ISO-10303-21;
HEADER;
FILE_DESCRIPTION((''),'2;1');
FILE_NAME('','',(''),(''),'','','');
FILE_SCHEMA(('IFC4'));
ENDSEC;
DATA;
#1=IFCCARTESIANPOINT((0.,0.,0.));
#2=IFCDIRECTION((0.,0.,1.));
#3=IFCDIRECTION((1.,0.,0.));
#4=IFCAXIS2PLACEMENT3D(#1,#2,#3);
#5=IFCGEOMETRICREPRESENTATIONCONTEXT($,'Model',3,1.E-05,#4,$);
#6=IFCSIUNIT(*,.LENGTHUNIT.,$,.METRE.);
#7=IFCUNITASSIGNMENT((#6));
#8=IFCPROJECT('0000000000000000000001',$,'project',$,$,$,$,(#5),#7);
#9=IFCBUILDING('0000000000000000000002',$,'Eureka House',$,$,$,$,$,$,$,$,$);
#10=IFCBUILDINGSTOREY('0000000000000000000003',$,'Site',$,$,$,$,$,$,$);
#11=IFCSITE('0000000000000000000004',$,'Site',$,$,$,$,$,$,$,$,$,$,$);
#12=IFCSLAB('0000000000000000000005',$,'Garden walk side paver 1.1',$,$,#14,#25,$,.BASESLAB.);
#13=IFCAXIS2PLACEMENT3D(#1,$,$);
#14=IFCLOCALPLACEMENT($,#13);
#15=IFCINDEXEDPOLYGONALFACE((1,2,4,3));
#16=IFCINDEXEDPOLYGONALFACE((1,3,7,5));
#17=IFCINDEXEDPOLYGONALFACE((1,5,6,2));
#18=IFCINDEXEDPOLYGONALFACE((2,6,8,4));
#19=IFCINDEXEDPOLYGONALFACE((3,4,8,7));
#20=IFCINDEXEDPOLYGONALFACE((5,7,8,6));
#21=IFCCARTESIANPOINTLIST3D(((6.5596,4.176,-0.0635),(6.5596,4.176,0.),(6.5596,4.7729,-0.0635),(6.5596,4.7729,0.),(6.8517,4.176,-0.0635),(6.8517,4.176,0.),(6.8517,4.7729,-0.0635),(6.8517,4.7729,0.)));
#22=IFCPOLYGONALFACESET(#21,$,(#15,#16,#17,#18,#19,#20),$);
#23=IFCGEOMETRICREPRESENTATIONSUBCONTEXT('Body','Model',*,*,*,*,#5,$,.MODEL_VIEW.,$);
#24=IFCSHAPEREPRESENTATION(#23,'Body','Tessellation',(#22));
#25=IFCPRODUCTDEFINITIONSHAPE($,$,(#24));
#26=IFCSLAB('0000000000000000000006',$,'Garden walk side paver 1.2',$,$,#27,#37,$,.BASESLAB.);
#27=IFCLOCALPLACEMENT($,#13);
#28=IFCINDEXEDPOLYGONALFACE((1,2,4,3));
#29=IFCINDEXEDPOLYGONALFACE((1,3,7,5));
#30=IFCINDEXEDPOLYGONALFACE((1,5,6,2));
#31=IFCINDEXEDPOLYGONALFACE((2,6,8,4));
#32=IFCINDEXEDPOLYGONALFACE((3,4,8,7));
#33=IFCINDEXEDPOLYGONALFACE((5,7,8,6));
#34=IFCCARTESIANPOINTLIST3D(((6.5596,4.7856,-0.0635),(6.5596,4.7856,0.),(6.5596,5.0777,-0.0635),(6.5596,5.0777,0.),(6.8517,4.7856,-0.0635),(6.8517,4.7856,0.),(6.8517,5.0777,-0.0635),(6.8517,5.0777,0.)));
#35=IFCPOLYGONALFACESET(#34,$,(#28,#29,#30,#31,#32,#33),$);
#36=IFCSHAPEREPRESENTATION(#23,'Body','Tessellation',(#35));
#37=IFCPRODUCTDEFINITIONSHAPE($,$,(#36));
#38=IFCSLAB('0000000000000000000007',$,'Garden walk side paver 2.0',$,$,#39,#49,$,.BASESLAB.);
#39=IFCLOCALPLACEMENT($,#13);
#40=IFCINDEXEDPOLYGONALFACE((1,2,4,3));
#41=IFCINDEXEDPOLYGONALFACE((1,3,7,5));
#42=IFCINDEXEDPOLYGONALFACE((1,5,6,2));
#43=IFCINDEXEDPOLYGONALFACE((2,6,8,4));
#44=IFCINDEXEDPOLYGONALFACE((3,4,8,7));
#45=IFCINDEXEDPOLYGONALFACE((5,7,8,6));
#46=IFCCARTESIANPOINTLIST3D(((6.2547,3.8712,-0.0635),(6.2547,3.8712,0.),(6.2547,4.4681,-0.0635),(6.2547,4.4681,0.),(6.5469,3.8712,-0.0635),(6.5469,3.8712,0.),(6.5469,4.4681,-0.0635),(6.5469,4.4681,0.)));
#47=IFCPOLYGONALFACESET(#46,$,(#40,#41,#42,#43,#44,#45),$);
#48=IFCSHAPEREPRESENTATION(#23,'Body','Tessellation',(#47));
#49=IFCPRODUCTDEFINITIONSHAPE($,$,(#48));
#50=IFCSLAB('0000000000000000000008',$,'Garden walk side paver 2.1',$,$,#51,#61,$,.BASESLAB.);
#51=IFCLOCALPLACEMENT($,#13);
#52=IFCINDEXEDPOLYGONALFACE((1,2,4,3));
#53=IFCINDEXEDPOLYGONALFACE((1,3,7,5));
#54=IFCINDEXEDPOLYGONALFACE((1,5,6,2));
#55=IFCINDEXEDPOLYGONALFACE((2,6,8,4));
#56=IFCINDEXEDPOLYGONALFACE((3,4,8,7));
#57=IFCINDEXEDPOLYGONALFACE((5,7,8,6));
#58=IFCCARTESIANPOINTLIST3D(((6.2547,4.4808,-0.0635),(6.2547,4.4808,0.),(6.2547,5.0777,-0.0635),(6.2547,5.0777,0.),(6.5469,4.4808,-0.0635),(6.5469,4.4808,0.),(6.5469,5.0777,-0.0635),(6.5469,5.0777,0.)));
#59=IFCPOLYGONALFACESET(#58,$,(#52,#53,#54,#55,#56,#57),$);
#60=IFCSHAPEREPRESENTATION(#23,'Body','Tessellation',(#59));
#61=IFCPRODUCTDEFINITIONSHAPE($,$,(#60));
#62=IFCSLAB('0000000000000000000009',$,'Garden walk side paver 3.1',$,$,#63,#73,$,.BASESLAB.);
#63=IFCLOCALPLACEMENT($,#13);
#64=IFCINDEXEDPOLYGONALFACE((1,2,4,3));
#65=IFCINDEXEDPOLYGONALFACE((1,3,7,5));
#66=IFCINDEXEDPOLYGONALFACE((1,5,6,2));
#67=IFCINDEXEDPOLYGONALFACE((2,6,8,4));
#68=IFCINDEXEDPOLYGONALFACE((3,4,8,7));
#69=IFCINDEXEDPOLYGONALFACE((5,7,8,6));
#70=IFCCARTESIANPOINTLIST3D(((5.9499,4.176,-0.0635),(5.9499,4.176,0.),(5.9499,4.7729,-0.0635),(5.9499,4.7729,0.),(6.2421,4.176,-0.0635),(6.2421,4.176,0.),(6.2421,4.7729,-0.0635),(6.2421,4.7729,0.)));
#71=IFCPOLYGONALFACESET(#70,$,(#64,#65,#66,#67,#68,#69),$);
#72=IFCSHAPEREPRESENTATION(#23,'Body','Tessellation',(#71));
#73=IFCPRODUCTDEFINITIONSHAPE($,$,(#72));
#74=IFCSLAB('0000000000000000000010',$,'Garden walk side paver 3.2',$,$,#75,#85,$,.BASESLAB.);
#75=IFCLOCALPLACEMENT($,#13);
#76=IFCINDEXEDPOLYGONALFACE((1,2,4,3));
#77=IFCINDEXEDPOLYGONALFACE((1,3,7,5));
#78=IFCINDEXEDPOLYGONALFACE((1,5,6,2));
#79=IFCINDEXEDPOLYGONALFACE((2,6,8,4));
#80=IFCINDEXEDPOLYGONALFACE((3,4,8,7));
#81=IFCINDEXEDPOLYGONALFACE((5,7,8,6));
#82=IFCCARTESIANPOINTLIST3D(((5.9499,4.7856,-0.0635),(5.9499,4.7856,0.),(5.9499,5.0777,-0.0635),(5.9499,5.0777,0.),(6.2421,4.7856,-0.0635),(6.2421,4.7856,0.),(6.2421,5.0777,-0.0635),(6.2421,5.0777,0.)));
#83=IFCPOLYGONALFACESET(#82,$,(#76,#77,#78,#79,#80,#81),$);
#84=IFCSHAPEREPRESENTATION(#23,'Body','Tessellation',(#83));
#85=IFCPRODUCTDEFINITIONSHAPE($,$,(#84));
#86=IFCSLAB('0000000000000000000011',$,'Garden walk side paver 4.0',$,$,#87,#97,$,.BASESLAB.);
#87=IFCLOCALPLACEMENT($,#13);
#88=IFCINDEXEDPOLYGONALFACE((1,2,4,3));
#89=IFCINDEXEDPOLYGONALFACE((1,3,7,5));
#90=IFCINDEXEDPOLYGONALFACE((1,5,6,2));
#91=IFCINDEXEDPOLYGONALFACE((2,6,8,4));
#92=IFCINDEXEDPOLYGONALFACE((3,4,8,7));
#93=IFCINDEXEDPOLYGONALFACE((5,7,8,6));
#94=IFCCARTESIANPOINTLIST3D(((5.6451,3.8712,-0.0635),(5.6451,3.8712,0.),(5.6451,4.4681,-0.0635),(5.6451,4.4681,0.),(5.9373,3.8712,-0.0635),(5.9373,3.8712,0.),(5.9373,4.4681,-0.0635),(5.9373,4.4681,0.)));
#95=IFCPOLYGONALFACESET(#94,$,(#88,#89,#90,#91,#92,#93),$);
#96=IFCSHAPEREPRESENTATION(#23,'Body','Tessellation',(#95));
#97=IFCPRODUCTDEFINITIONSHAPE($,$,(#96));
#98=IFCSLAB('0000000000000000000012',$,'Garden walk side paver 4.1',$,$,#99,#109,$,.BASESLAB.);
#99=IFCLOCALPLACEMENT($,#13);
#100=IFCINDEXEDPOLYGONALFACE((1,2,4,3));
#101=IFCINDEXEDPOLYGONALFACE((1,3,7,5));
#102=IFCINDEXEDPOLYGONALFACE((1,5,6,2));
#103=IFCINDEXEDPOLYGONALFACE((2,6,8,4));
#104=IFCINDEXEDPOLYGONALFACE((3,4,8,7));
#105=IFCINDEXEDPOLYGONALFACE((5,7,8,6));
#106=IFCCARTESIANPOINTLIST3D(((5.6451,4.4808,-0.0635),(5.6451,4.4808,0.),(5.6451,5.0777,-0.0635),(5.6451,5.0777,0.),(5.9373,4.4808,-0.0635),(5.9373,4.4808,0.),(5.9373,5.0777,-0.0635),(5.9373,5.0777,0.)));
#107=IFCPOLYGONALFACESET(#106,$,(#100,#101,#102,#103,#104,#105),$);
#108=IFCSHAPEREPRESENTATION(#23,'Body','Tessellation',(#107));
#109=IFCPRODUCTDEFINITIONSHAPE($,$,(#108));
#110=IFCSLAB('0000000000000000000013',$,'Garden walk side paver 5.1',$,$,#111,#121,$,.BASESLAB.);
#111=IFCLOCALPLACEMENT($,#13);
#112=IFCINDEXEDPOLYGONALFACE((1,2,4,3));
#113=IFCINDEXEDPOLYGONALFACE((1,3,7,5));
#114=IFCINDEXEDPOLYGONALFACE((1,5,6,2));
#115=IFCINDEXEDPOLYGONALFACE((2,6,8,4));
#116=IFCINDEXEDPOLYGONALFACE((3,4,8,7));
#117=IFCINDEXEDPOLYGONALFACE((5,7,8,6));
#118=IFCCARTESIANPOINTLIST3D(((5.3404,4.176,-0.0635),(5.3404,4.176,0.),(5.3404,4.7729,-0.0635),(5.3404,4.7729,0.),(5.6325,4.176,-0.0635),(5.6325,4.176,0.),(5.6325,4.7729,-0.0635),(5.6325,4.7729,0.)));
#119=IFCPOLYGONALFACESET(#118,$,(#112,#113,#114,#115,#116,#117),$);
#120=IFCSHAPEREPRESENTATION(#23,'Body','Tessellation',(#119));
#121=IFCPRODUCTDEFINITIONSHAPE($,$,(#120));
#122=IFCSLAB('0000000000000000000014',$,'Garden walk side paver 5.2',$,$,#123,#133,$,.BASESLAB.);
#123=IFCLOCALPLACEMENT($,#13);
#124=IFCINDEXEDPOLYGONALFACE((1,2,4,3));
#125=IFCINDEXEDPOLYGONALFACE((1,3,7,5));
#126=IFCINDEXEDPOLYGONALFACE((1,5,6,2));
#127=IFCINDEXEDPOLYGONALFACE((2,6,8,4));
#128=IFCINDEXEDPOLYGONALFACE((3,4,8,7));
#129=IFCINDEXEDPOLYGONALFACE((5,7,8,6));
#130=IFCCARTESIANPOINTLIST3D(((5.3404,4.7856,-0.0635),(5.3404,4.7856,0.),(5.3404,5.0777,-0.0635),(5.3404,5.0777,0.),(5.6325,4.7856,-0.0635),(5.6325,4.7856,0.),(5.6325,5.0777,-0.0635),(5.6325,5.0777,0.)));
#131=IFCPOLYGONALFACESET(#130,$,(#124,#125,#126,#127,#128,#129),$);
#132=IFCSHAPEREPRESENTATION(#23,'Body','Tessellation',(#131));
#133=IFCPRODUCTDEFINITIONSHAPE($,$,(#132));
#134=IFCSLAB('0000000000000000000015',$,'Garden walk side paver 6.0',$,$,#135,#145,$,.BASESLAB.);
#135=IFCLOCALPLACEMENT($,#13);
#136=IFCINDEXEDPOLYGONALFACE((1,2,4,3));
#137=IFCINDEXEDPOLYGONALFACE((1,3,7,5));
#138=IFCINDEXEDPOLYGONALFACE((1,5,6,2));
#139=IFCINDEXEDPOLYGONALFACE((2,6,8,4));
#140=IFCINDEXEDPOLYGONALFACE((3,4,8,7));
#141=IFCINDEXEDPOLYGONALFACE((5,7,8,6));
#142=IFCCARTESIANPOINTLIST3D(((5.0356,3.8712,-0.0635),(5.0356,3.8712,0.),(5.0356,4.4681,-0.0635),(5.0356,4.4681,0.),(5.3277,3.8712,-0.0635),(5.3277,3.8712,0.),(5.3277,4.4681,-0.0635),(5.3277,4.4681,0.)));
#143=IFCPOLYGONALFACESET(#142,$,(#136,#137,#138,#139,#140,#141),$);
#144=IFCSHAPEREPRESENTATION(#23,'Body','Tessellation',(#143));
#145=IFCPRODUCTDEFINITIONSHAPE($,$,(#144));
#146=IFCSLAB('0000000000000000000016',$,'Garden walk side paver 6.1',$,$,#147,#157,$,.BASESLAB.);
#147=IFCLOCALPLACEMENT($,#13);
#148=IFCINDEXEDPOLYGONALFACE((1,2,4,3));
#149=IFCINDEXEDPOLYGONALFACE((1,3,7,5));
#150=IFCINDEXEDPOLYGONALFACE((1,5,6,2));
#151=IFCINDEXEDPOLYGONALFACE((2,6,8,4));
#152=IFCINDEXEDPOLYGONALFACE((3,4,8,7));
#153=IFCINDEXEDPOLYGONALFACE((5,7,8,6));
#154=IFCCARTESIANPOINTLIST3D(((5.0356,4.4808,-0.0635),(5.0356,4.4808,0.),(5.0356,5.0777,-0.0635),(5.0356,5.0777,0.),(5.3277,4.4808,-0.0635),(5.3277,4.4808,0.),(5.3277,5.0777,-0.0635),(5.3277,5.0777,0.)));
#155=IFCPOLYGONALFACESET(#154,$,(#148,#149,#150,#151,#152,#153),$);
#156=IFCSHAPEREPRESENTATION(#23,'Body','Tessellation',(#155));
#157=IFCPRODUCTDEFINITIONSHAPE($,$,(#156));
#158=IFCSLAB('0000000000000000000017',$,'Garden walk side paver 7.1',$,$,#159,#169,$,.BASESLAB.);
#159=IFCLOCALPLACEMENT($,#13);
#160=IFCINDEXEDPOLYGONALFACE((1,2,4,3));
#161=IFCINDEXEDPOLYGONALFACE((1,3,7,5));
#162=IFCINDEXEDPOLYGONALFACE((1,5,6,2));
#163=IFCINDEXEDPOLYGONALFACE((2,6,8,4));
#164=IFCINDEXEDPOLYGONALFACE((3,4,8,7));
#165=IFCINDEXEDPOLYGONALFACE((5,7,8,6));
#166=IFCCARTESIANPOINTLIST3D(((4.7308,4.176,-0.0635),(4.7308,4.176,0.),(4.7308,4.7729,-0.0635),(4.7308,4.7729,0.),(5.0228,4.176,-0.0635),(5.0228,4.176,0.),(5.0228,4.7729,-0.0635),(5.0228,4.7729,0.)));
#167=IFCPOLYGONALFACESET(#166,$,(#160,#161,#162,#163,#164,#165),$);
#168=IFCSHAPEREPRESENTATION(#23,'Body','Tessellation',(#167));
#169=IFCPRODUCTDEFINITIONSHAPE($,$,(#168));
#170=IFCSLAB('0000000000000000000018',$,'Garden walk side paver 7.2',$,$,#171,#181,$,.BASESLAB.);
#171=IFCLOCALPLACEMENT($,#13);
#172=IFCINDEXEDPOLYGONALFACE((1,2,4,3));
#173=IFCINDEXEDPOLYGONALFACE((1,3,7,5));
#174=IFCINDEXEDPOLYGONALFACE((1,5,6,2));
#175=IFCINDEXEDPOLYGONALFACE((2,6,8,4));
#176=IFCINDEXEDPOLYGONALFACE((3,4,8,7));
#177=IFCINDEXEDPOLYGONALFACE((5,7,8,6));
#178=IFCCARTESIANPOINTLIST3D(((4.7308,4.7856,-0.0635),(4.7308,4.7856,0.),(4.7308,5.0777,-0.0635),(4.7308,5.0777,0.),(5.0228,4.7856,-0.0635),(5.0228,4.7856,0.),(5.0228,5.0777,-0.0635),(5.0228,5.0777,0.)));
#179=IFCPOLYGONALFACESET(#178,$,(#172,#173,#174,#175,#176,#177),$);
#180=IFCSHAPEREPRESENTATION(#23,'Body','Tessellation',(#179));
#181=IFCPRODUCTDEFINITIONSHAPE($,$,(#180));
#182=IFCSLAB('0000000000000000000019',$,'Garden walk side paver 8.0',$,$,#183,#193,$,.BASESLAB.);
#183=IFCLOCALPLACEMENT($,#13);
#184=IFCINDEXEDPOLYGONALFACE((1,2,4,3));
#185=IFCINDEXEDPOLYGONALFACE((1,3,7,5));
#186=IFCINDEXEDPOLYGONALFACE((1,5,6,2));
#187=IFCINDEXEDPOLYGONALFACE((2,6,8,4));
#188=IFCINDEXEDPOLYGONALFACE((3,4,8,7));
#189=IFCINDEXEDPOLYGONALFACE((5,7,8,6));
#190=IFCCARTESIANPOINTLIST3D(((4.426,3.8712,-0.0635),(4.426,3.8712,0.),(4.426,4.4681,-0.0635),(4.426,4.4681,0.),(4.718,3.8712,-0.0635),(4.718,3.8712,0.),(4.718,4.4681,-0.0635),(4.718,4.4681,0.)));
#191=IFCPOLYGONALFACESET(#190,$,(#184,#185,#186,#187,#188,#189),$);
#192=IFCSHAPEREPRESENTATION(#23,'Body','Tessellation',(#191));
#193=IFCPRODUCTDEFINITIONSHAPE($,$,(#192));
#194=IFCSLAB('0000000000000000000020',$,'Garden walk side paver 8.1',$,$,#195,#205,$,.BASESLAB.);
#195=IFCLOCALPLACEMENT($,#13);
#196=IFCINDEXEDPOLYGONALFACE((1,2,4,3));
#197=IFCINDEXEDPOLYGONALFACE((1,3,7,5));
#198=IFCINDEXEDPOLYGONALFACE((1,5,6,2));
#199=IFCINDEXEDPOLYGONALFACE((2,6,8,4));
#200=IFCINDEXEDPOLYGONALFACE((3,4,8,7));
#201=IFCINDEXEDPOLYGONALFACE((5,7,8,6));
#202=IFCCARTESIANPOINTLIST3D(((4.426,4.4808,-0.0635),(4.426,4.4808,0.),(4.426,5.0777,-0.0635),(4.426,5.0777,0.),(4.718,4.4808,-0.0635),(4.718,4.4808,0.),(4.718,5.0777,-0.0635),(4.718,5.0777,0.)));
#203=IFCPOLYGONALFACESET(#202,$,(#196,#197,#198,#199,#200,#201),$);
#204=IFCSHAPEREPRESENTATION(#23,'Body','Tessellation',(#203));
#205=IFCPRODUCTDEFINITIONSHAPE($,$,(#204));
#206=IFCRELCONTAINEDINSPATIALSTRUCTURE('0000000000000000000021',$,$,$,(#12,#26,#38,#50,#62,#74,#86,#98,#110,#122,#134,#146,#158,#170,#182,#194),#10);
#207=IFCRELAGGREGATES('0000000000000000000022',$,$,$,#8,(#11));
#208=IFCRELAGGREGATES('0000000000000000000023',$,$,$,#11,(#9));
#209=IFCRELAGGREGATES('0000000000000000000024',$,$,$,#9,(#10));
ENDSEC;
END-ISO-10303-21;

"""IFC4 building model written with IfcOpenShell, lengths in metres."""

from ifc_helpers import new_model, si_unit, frame, origin, origin_with_axes, origin_2d, place, context, subcontext, project, spatial, rectangle, extrude, element, save


model = new_model("IFC4")

# Units and contexts
model_context = context("Model", 3, precision=1e-05, world=origin_with_axes())
body_context = subcontext(model_context, "Body", "Model", "MODEL_VIEW")
ifc_project = project(units=[si_unit("LENGTHUNIT", "METRE")], contexts=[model_context])

# Site, building, storey
site = spatial("IfcSite", under=ifc_project, Name="Site")
building = spatial("IfcBuilding", under=site, Name="Eureka House")
storey = spatial("IfcBuildingStorey", under=building, Name="Site")

# Slabs
slab_1_placement = place(None, frame((6.7056, 4.4745, -0.0635), z_axis=(0.0, 0.0, 1.0), x_axis=(1.0, 0.0, 0.0)))
element("IfcSlab", 1, at=slab_1_placement, inside=storey, Name="Garden walk side paver 1.1", PredefinedType="BASESLAB", context=body_context, shape_type="SweptSolid", body=[
    extrude(rectangle(XDim=0.2921, YDim=0.5969, at=origin_2d()), origin(), (0.0, 0.0, 1.0), 0.0635),
])
slab_2_placement = place(None, frame((6.7056, 4.9317, -0.0635), z_axis=(0.0, 0.0, 1.0), x_axis=(1.0, 0.0, 0.0)))
element("IfcSlab", 2, at=slab_2_placement, inside=storey, Name="Garden walk side paver 1.2", PredefinedType="BASESLAB", context=body_context, shape_type="SweptSolid", body=[
    extrude(rectangle(XDim=0.2921, YDim=0.2921, at=origin_2d()), origin(), (0.0, 0.0, 1.0), 0.0635),
])
slab_3_placement = place(None, frame((6.4008, 4.1697, -0.0635), z_axis=(0.0, 0.0, 1.0), x_axis=(1.0, 0.0, 0.0)))
element("IfcSlab", 3, at=slab_3_placement, inside=storey, Name="Garden walk side paver 2.0", PredefinedType="BASESLAB", context=body_context, shape_type="SweptSolid", body=[
    extrude(rectangle(XDim=0.2921, YDim=0.5969, at=origin_2d()), origin(), (0.0, 0.0, 1.0), 0.0635),
])
slab_4_placement = place(None, frame((6.4008, 4.7793, -0.0635), z_axis=(0.0, 0.0, 1.0), x_axis=(1.0, 0.0, 0.0)))
element("IfcSlab", 4, at=slab_4_placement, inside=storey, Name="Garden walk side paver 2.1", PredefinedType="BASESLAB", context=body_context, shape_type="SweptSolid", body=[
    extrude(rectangle(XDim=0.2921, YDim=0.5969, at=origin_2d()), origin(), (0.0, 0.0, 1.0), 0.0635),
])
slab_5_placement = place(None, frame((6.096, 4.4745, -0.0635), z_axis=(0.0, 0.0, 1.0), x_axis=(1.0, 0.0, 0.0)))
element("IfcSlab", 5, at=slab_5_placement, inside=storey, Name="Garden walk side paver 3.1", PredefinedType="BASESLAB", context=body_context, shape_type="SweptSolid", body=[
    extrude(rectangle(XDim=0.2921, YDim=0.5969, at=origin_2d()), origin(), (0.0, 0.0, 1.0), 0.0635),
])
slab_6_placement = place(None, frame((6.096, 4.9317, -0.0635), z_axis=(0.0, 0.0, 1.0), x_axis=(1.0, 0.0, 0.0)))
element("IfcSlab", 6, at=slab_6_placement, inside=storey, Name="Garden walk side paver 3.2", PredefinedType="BASESLAB", context=body_context, shape_type="SweptSolid", body=[
    extrude(rectangle(XDim=0.2921, YDim=0.2921, at=origin_2d()), origin(), (0.0, 0.0, 1.0), 0.0635),
])
slab_7_placement = place(None, frame((5.7912, 4.1697, -0.0635), z_axis=(0.0, 0.0, 1.0), x_axis=(1.0, 0.0, 0.0)))
element("IfcSlab", 7, at=slab_7_placement, inside=storey, Name="Garden walk side paver 4.0", PredefinedType="BASESLAB", context=body_context, shape_type="SweptSolid", body=[
    extrude(rectangle(XDim=0.2921, YDim=0.5969, at=origin_2d()), origin(), (0.0, 0.0, 1.0), 0.0635),
])
slab_8_placement = place(None, frame((5.7912, 4.7793, -0.0635), z_axis=(0.0, 0.0, 1.0), x_axis=(1.0, 0.0, 0.0)))
element("IfcSlab", 8, at=slab_8_placement, inside=storey, Name="Garden walk side paver 4.1", PredefinedType="BASESLAB", context=body_context, shape_type="SweptSolid", body=[
    extrude(rectangle(XDim=0.2921, YDim=0.5969, at=origin_2d()), origin(), (0.0, 0.0, 1.0), 0.0635),
])
slab_9_placement = place(None, frame((5.4864, 4.4745, -0.0635), z_axis=(0.0, 0.0, 1.0), x_axis=(1.0, 0.0, 0.0)))
element("IfcSlab", 9, at=slab_9_placement, inside=storey, Name="Garden walk side paver 5.1", PredefinedType="BASESLAB", context=body_context, shape_type="SweptSolid", body=[
    extrude(rectangle(XDim=0.2921, YDim=0.5969, at=origin_2d()), origin(), (0.0, 0.0, 1.0), 0.0635),
])
slab_10_placement = place(None, frame((5.4864, 4.9317, -0.0635), z_axis=(0.0, 0.0, 1.0), x_axis=(1.0, 0.0, 0.0)))
element("IfcSlab", 10, at=slab_10_placement, inside=storey, Name="Garden walk side paver 5.2", PredefinedType="BASESLAB", context=body_context, shape_type="SweptSolid", body=[
    extrude(rectangle(XDim=0.2921, YDim=0.2921, at=origin_2d()), origin(), (0.0, 0.0, 1.0), 0.0635),
])
slab_11_placement = place(None, frame((5.1816, 4.1697, -0.0635), z_axis=(0.0, 0.0, 1.0), x_axis=(1.0, 0.0, 0.0)))
element("IfcSlab", 11, at=slab_11_placement, inside=storey, Name="Garden walk side paver 6.0", PredefinedType="BASESLAB", context=body_context, shape_type="SweptSolid", body=[
    extrude(rectangle(XDim=0.2921, YDim=0.5969, at=origin_2d()), origin(), (0.0, 0.0, 1.0), 0.0635),
])
slab_12_placement = place(None, frame((5.1816, 4.7793, -0.0635), z_axis=(0.0, 0.0, 1.0), x_axis=(1.0, 0.0, 0.0)))
element("IfcSlab", 12, at=slab_12_placement, inside=storey, Name="Garden walk side paver 6.1", PredefinedType="BASESLAB", context=body_context, shape_type="SweptSolid", body=[
    extrude(rectangle(XDim=0.2921, YDim=0.5969, at=origin_2d()), origin(), (0.0, 0.0, 1.0), 0.0635),
])
slab_13_placement = place(None, frame((4.8768, 4.4745, -0.0635), z_axis=(0.0, 0.0, 1.0), x_axis=(1.0, 0.0, 0.0)))
element("IfcSlab", 13, at=slab_13_placement, inside=storey, Name="Garden walk side paver 7.1", PredefinedType="BASESLAB", context=body_context, shape_type="SweptSolid", body=[
    extrude(rectangle(XDim=0.2921, YDim=0.5969, at=origin_2d()), origin(), (0.0, 0.0, 1.0), 0.0635),
])
slab_14_placement = place(None, frame((4.8768, 4.9317, -0.0635), z_axis=(0.0, 0.0, 1.0), x_axis=(1.0, 0.0, 0.0)))
element("IfcSlab", 14, at=slab_14_placement, inside=storey, Name="Garden walk side paver 7.2", PredefinedType="BASESLAB", context=body_context, shape_type="SweptSolid", body=[
    extrude(rectangle(XDim=0.2921, YDim=0.2921, at=origin_2d()), origin(), (0.0, 0.0, 1.0), 0.0635),
])
slab_15_placement = place(None, frame((4.572, 4.1697, -0.0635), z_axis=(0.0, 0.0, 1.0), x_axis=(1.0, 0.0, 0.0)))
element("IfcSlab", 15, at=slab_15_placement, inside=storey, Name="Garden walk side paver 8.0", PredefinedType="BASESLAB", context=body_context, shape_type="SweptSolid", body=[
    extrude(rectangle(XDim=0.2921, YDim=0.5969, at=origin_2d()), origin(), (0.0, 0.0, 1.0), 0.0635),
])
slab_16_placement = place(None, frame((4.572, 4.7793, -0.0635), z_axis=(0.0, 0.0, 1.0), x_axis=(1.0, 0.0, 0.0)))
element("IfcSlab", 16, at=slab_16_placement, inside=storey, Name="Garden walk side paver 8.1", PredefinedType="BASESLAB", context=body_context, shape_type="SweptSolid", body=[
    extrude(rectangle(XDim=0.2921, YDim=0.5969, at=origin_2d()), origin(), (0.0, 0.0, 1.0), 0.0635),
])

save(model, "model.ifc")
